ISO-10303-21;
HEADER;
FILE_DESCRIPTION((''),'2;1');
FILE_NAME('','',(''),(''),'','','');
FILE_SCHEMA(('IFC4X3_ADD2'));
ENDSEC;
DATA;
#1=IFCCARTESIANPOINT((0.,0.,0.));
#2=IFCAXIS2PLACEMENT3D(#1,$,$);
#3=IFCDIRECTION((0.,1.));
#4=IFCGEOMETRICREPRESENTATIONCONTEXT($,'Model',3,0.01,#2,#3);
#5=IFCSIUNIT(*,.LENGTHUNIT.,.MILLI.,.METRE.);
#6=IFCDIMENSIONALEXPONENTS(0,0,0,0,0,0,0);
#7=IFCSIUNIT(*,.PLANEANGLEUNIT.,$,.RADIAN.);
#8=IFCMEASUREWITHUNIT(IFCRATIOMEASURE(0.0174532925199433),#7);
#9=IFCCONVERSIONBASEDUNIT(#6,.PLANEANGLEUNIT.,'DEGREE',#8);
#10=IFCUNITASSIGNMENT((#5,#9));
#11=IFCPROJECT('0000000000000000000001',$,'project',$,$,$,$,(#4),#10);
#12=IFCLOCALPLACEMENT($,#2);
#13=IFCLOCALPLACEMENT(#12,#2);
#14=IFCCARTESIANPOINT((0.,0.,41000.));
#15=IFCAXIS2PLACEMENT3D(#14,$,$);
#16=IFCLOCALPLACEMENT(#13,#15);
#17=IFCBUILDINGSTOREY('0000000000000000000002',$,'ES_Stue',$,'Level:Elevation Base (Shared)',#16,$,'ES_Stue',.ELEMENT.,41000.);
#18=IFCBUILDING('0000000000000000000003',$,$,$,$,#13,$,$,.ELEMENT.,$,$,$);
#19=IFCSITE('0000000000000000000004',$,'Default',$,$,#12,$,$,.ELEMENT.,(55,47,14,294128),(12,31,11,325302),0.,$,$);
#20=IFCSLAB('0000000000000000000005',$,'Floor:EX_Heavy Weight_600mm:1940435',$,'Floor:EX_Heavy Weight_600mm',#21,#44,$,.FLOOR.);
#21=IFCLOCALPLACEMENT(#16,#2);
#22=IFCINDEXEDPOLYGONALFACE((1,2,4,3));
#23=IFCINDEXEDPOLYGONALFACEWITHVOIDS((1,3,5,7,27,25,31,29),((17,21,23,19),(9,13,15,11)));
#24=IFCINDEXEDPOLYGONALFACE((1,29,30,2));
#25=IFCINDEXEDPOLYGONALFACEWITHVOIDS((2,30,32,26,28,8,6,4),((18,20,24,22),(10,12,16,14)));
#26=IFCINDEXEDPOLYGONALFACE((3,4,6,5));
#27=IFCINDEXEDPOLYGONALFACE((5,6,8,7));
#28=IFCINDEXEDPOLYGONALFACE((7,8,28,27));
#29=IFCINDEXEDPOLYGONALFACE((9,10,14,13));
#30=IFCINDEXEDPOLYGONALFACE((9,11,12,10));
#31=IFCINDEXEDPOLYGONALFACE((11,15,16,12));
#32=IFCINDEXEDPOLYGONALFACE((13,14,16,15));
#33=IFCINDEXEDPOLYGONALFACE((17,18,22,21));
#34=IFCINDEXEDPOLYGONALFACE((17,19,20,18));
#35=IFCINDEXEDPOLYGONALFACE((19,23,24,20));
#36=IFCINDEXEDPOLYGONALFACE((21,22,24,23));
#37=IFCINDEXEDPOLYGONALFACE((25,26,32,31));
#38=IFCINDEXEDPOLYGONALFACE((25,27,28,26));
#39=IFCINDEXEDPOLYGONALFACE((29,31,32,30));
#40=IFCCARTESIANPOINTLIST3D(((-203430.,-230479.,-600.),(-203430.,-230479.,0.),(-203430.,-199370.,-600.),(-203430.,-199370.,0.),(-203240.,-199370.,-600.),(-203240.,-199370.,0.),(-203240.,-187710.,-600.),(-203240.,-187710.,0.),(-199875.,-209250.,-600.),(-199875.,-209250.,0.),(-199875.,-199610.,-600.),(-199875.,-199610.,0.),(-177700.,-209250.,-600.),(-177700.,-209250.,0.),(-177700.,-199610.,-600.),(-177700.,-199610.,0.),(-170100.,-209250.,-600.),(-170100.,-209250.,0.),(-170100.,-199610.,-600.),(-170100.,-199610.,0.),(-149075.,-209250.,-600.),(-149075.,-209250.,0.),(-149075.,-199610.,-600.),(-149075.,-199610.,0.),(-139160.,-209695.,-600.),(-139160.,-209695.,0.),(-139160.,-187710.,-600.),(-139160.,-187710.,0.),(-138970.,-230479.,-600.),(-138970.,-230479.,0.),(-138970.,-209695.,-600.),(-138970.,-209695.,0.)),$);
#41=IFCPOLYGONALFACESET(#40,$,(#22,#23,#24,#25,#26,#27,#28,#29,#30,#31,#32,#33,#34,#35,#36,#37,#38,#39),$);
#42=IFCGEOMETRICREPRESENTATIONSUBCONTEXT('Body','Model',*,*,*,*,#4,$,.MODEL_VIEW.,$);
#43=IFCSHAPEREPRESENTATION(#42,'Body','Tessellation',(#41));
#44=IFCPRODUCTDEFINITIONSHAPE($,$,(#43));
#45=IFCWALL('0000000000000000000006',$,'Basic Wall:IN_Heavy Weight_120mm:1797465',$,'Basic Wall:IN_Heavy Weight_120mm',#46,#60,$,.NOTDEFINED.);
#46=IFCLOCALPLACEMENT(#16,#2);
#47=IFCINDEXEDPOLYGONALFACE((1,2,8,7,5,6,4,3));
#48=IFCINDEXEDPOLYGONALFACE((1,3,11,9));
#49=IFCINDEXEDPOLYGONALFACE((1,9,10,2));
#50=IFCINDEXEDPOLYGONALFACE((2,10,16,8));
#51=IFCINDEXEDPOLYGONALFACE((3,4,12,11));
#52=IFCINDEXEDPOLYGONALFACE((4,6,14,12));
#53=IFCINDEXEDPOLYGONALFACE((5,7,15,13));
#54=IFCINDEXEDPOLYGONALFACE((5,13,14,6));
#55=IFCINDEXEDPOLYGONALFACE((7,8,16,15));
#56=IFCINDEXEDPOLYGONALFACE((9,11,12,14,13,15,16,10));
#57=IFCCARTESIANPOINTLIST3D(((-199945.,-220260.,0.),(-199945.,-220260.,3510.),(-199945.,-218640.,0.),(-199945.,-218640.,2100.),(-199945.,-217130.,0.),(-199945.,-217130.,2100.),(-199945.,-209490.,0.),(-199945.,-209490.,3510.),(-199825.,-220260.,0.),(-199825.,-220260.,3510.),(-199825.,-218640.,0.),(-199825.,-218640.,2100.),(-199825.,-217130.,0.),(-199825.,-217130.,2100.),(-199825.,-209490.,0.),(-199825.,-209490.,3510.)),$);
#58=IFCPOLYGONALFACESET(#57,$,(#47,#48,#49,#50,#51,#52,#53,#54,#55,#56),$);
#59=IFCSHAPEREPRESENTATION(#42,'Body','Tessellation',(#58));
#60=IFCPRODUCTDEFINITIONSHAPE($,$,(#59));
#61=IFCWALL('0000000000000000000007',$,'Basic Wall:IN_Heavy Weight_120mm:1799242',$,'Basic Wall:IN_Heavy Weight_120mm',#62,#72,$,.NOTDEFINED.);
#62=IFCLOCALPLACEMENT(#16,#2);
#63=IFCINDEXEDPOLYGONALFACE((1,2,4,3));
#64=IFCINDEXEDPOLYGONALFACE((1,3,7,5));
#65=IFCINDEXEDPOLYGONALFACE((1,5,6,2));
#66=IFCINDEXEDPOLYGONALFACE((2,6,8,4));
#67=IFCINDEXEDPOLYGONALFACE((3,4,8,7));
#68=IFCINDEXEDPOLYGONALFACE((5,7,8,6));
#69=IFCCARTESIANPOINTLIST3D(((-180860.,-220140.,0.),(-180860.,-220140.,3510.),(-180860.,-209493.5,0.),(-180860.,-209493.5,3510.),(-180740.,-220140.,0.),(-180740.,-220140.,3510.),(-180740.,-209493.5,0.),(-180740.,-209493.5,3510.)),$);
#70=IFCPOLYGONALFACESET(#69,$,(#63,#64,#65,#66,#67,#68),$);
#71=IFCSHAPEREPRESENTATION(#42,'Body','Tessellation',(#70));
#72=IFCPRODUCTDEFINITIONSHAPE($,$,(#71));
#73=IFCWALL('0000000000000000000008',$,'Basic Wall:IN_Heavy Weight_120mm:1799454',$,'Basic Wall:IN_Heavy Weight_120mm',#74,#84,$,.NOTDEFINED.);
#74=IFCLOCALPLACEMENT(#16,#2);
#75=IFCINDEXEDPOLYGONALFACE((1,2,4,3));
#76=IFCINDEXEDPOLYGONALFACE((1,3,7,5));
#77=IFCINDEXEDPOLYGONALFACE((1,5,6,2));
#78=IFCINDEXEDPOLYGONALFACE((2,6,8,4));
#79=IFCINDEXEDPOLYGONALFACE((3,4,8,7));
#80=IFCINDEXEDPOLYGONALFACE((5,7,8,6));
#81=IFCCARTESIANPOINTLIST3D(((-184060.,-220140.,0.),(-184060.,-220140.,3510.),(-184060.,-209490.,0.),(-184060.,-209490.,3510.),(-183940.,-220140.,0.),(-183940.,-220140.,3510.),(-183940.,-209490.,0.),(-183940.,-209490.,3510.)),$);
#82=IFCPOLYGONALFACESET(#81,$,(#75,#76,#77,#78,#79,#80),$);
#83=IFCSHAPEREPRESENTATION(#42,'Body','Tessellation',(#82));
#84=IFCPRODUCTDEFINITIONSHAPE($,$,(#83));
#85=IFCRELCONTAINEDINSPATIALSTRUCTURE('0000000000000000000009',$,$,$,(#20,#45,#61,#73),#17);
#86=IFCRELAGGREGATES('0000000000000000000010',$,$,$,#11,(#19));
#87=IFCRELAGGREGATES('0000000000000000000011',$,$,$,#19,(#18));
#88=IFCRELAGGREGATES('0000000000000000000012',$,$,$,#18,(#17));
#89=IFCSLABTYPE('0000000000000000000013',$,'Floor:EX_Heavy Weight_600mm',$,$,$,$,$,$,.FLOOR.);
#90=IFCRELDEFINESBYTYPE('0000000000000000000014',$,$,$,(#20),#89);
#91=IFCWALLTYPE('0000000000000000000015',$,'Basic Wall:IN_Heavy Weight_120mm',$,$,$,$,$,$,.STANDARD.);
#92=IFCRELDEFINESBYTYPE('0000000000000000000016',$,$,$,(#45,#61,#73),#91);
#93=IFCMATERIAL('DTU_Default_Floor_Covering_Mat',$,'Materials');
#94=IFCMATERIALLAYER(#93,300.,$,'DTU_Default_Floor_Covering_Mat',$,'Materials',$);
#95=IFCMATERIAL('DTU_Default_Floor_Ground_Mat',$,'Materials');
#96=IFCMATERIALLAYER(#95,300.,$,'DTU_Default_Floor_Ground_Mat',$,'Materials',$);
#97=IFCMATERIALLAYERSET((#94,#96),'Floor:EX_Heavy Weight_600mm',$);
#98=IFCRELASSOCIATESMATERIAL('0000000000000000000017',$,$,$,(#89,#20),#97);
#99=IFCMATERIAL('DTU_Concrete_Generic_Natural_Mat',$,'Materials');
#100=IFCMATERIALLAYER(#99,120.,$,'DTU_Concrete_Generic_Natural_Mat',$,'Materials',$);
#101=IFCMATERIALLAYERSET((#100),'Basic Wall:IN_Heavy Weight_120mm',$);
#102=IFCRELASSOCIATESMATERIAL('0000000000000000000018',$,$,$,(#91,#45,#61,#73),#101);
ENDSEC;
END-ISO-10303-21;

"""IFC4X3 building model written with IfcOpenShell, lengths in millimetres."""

from ifc_helpers import new_model, entity, si_unit, converted_unit, direction, frame, frame_2d, origin, place, context, subcontext, project, spatial, polyline, rectangle, outline, extrude, material, layer, layer_set, layer_usage, type_object, element, save


model = new_model("IFC4X3")

# Units and contexts
model_context = context("Model", 3, precision=0.01, world=origin(), true_north=direction((0.0, 1.0)))
body_context = subcontext(model_context, "Body", "Model", "MODEL_VIEW")
ifc_project = project(units=[si_unit("LENGTHUNIT", "METRE", prefix="MILLI"), converted_unit("PLANEANGLEUNIT", "DEGREE", entity("IfcRatioMeasure", 0.0174532925199433), si_unit("PLANEANGLEUNIT", "RADIAN"), dimensions=[0, 0, 0, 0, 0, 0, 0])], contexts=[model_context])

# Site, building, storey
site_placement = place(None, origin())
site = spatial("IfcSite", under=ifc_project, at=site_placement, Name="Default", CompositionType="ELEMENT", RefLatitude=(55, 47, 14, 294128), RefLongitude=(12, 31, 11, 325302), RefElevation=0.0)
building_placement = place(site_placement, origin())
building = spatial("IfcBuilding", under=site, at=building_placement, CompositionType="ELEMENT")
storey_placement = place(building_placement, frame((0.0, 0.0, 41000.0)))
storey = spatial("IfcBuildingStorey", under=building, at=storey_placement, Name="ES_Stue", ObjectType="Level:Elevation Base (Shared)", LongName="ES_Stue", CompositionType="ELEMENT", Elevation=41000.0)

# Slab, openings
ifc_material_1 = material(Name="DTU_Default_Floor_Covering_Mat", Category="Materials")
ifc_layer_1 = layer(ifc_material_1, 300.0, Name="DTU_Default_Floor_Covering_Mat", Category="Materials")
ifc_material_2 = material(Name="DTU_Default_Floor_Ground_Mat", Category="Materials")
ifc_layer_2 = layer(ifc_material_2, 300.0, Name="DTU_Default_Floor_Ground_Mat", Category="Materials")
ifc_layer_set_1 = layer_set([ifc_layer_1, ifc_layer_2], Name="Floor:EX_Heavy Weight_600mm")
ifc_layer_usage = layer_usage(ifc_layer_set_1, "AXIS3", "POSITIVE", 0.0)
slab_type = type_object("IfcSlabType", Name="Floor:EX_Heavy Weight_600mm", PredefinedType="FLOOR", material=ifc_layer_set_1)
slab_placement = place(storey_placement, frame((-203430.0, -230479.0, -600.0)))
slab = element("IfcSlab", 1, at=slab_placement, inside=storey, type_object=slab_type, material=ifc_layer_usage, Name="Floor:EX_Heavy Weight_600mm:1940435", ObjectType="Floor:EX_Heavy Weight_600mm", PredefinedType="FLOOR", context=body_context, shape_type="SweptSolid", body=[
    extrude(outline(polyline([(-32040.0, 21384.5), (-32040.0, -600.5), (-32230.0, -600.5), (-32230.0, -21384.5), (32230.0, -21384.5), (32230.0, 9724.5), (32040.0, 9724.5), (32040.0, 21384.5), (-32040.0, 21384.5)])), frame((32230.0, 21384.5, 600.0), z_axis=(0.0, 0.0, -1.0), x_axis=(-1.0, 0.0, 0.0)), (0.0, 0.0, 1.0), 600.0),
])
opening_1_placement = place(slab_placement, origin())
element("IfcOpeningElement", 2, at=opening_1_placement, cuts=slab, PredefinedType="OPENING", context=body_context, shape_type="SweptSolid", body=[
    extrude(rectangle(XDim=9640.0, YDim=22175.0, at=frame_2d((0.0, 0.0), x_axis=(1.0, 0.0))), frame((14642.5, 26049.0, 600.0), z_axis=(0.0, 0.0, -1.0), x_axis=(0.0, -1.0, 0.0)), (0.0, 0.0, 1.0), 600.0),
])
opening_2_placement = place(slab_placement, origin())
element("IfcOpeningElement", 3, at=opening_2_placement, cuts=slab, PredefinedType="OPENING", context=body_context, shape_type="SweptSolid", body=[
    extrude(rectangle(XDim=9640.0, YDim=21025.0, at=frame_2d((0.0, 0.0), x_axis=(1.0, 0.0))), frame((43842.5, 26049.0, 600.0), z_axis=(0.0, 0.0, -1.0), x_axis=(0.0, -1.0, 0.0)), (0.0, 0.0, 1.0), 600.0),
])

# Wall, opening
ifc_material_3 = material(Name="DTU_Concrete_Generic_Natural_Mat", Category="Materials")
ifc_layer_3 = layer(ifc_material_3, 120.0, Name="DTU_Concrete_Generic_Natural_Mat", Category="Materials")
ifc_layer_set_2 = layer_set([ifc_layer_3], Name="Basic Wall:IN_Heavy Weight_120mm")
wall_type_1 = type_object("IfcWallType", Name="Basic Wall:IN_Heavy Weight_120mm", PredefinedType="STANDARD", material=ifc_layer_set_2)
wall_1_placement = place(storey_placement, frame((-199885.0, -209490.0, 0.0), z_axis=(0.0, 0.0, 1.0), x_axis=(0.0, -1.0, 0.0)))
wall_1 = element("IfcWall", 4, at=wall_1_placement, inside=storey, type_object=wall_type_1, material=ifc_layer_set_2, Name="Basic Wall:IN_Heavy Weight_120mm:1797465", ObjectType="Basic Wall:IN_Heavy Weight_120mm", PredefinedType="NOTDEFINED", context=body_context, shape_type="SweptSolid", body=[
    extrude(rectangle(XDim=10770.0, YDim=120.0, at=frame_2d((5385.0, 0.0), x_axis=(1.0, 0.0))), origin(), (0.0, 0.0, 1.0), 3510.0),
])
opening_3_placement = place(wall_1_placement, frame((7640.0, -60.0, 0.0)))
element("IfcOpeningElement", 5, at=opening_3_placement, cuts=wall_1, PredefinedType="OPENING", context=body_context, shape_type="SweptSolid", body=[
    extrude(rectangle(XDim=2100.0, YDim=1510.0, at=frame_2d((1050.0, 755.0), x_axis=(1.0, 0.0))), frame((0.0, 0.0, 0.0), z_axis=(0.0, 1.0, 0.0), x_axis=(0.0, 0.0, 1.0)), (0.0, 0.0, 1.0), 120.0),
])

# Walls
wall_2_placement = place(storey_placement, frame((-180800.0, -209493.5, 0.0), z_axis=(0.0, 0.0, 1.0), x_axis=(0.0, -1.0, 0.0)))
element("IfcWall", 6, at=wall_2_placement, inside=storey, type_object=wall_type_1, material=ifc_layer_set_2, Name="Basic Wall:IN_Heavy Weight_120mm:1799242", ObjectType="Basic Wall:IN_Heavy Weight_120mm", PredefinedType="NOTDEFINED", context=body_context, shape_type="SweptSolid", body=[
    extrude(rectangle(XDim=10646.5, YDim=120.0, at=frame_2d((5323.3, 0.0), x_axis=(-1.0, 0.0))), origin(), (0.0, 0.0, 1.0), 3510.0),
])
wall_3_placement = place(storey_placement, frame((-184000.0, -220140.0, 0.0), z_axis=(0.0, 0.0, 1.0), x_axis=(0.0, 1.0, 0.0)))
element("IfcWall", 7, at=wall_3_placement, inside=storey, type_object=wall_type_1, material=ifc_layer_set_2, Name="Basic Wall:IN_Heavy Weight_120mm:1799454", ObjectType="Basic Wall:IN_Heavy Weight_120mm", PredefinedType="NOTDEFINED", context=body_context, shape_type="SweptSolid", body=[
    extrude(rectangle(XDim=10650.0, YDim=120.0, at=frame_2d((5325.0, 0.0), x_axis=(-1.0, 0.0))), origin(), (0.0, 0.0, 1.0), 3510.0),
])

save(model, "model.ifc")
